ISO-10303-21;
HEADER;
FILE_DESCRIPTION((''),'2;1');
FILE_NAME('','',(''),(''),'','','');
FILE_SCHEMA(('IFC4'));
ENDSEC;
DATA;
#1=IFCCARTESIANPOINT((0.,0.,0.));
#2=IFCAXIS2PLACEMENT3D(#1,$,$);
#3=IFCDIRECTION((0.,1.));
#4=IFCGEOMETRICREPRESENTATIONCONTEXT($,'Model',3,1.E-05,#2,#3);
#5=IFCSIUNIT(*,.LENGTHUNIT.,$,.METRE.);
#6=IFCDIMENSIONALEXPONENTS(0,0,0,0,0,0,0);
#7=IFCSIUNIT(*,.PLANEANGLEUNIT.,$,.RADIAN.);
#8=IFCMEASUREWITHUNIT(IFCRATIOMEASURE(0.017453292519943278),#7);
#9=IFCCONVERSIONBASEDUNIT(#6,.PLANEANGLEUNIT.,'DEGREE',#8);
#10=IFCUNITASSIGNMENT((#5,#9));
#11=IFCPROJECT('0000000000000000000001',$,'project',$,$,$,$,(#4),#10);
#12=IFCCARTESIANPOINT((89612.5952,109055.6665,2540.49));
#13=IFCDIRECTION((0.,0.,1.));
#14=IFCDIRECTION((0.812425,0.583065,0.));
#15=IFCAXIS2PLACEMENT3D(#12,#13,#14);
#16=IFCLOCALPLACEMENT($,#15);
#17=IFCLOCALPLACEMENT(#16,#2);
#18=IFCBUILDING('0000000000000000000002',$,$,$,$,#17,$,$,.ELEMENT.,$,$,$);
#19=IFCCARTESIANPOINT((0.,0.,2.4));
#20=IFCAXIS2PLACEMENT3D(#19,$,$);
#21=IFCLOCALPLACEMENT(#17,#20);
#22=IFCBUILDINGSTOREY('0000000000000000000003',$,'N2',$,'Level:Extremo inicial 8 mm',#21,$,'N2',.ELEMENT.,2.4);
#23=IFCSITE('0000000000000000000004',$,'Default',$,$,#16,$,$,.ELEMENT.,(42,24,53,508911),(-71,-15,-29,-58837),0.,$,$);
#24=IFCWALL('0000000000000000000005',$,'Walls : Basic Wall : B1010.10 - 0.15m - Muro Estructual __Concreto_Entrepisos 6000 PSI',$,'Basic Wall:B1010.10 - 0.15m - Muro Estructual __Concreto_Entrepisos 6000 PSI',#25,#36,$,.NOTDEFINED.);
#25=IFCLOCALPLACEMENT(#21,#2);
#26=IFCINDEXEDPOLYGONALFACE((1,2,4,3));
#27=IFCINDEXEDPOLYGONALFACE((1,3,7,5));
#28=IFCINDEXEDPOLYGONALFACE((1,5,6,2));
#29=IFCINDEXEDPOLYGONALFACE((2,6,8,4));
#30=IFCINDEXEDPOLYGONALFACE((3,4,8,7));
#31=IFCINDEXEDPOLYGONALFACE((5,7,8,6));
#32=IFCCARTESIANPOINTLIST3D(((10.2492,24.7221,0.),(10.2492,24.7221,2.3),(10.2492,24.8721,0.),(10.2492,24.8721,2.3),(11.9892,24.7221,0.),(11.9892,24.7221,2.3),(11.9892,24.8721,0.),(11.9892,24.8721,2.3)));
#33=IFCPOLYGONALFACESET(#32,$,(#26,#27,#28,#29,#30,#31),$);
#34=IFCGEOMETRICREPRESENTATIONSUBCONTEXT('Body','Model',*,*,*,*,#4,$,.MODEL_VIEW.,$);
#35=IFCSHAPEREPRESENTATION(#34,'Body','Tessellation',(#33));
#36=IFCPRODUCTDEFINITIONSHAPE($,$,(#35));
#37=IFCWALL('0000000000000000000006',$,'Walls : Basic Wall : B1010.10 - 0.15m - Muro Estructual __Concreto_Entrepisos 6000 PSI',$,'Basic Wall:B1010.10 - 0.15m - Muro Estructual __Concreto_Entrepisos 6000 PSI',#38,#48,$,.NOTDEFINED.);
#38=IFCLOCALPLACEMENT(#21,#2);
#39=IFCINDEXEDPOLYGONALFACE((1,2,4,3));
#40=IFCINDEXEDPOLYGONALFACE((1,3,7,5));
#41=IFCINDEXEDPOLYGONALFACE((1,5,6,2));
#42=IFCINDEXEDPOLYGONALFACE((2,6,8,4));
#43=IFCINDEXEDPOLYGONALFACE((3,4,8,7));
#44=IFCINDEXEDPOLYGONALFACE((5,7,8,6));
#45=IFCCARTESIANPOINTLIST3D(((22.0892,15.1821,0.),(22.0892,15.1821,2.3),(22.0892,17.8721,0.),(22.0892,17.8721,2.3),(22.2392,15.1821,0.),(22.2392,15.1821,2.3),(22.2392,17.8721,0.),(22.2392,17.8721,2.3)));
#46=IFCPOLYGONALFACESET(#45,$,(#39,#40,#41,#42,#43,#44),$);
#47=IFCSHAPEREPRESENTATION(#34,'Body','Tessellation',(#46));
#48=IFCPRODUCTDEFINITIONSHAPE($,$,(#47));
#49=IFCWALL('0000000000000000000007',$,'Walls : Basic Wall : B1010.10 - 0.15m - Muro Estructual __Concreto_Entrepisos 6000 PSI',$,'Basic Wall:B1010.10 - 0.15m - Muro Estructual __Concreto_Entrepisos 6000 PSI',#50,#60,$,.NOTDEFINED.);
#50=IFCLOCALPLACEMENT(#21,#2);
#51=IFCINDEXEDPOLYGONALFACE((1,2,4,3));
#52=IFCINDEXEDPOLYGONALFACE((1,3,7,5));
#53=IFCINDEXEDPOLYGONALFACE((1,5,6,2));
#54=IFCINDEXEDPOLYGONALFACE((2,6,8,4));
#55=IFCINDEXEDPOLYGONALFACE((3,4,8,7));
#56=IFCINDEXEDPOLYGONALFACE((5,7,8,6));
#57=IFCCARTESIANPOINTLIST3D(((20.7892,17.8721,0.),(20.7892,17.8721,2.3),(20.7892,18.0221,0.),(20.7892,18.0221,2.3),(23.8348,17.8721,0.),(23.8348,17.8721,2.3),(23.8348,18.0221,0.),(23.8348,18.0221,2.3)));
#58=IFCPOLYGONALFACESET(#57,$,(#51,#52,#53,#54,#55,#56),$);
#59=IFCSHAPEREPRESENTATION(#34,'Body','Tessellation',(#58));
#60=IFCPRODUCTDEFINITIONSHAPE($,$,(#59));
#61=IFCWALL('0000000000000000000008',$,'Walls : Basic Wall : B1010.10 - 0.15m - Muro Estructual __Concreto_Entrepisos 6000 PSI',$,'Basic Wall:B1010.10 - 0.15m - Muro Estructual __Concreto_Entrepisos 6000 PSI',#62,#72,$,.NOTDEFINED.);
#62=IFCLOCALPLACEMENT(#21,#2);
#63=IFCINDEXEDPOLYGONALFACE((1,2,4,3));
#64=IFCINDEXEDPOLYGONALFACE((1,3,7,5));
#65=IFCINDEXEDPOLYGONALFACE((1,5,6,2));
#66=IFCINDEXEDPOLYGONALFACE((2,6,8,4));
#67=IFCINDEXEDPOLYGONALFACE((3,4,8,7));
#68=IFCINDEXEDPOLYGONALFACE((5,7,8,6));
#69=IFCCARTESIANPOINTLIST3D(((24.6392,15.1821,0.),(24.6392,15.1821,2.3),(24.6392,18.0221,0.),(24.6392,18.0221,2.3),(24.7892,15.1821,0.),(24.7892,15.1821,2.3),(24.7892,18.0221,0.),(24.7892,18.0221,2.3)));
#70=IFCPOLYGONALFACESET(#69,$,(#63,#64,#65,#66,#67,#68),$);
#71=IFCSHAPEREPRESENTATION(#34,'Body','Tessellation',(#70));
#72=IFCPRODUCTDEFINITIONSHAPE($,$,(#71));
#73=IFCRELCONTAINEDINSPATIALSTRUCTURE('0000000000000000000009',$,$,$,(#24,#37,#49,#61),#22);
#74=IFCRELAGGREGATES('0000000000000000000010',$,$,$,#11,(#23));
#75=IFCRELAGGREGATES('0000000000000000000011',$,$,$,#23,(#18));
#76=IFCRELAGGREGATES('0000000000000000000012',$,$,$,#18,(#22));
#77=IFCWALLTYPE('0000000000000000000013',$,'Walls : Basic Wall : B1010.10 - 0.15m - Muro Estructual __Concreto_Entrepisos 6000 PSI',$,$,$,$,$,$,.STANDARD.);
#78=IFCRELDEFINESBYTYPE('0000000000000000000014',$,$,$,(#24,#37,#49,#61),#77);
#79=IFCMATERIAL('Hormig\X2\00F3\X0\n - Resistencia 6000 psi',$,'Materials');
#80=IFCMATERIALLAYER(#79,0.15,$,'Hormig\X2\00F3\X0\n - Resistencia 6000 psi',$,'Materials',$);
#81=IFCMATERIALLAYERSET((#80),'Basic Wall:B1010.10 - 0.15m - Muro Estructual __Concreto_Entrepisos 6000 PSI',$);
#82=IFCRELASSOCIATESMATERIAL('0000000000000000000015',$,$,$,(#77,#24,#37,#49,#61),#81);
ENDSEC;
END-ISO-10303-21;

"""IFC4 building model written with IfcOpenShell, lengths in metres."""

from ifc_helpers import new_model, entity, si_unit, converted_unit, direction, frame, frame_2d, origin, place, context, subcontext, project, spatial, rectangle, extrude, material, layer, layer_set, layer_usage, type_object, element, save


model = new_model("IFC4")

# Units and contexts
model_context = context("Model", 3, precision=1e-05, world=origin(), true_north=direction((0.0, 1.0)))
body_context = subcontext(model_context, "Body", "Model", "MODEL_VIEW")
ifc_project = project(units=[si_unit("LENGTHUNIT", "METRE"), converted_unit("PLANEANGLEUNIT", "DEGREE", entity("IfcRatioMeasure", 0.017453292519943278), si_unit("PLANEANGLEUNIT", "RADIAN"), dimensions=[0, 0, 0, 0, 0, 0, 0])], contexts=[model_context])

# Site, building, storey
site_placement = place(None, frame((89612.5952, 109055.6665, 2540.49), z_axis=(0.0, 0.0, 1.0), x_axis=(0.812425, 0.583065, 0.0)))
site = spatial("IfcSite", under=ifc_project, at=site_placement, Name="Default", CompositionType="ELEMENT", RefLatitude=(42, 24, 53, 508911), RefLongitude=(-71, -15, -29, -58837), RefElevation=0.0)
building_placement = place(site_placement, origin())
building = spatial("IfcBuilding", under=site, at=building_placement, CompositionType="ELEMENT")
storey_placement = place(building_placement, frame((0.0, 0.0, 2.4)))
storey = spatial("IfcBuildingStorey", under=building, at=storey_placement, Name="N2", ObjectType="Level:Extremo inicial 8 mm", LongName="N2", CompositionType="ELEMENT", Elevation=2.4)

# Walls
ifc_material = material(Name="Hormigón - Resistencia 6000 psi", Category="Materials")
ifc_layer_1 = layer(ifc_material, 0.15, Name="Hormigón - Resistencia 6000 psi", Category="Materials")
ifc_layer_set_1 = layer_set([ifc_layer_1], Name="Basic Wall:B1010.10 - 0.15m - Muro Estructual __Concreto_Entrepisos 6000 PSI")
wall_type_1 = type_object("IfcWallType", Name="Walls : Basic Wall : B1010.10 - 0.15m - Muro Estructual __Concreto_Entrepisos 6000 PSI", PredefinedType="STANDARD", material=ifc_layer_set_1)
ifc_layer_usage_1 = layer_usage(ifc_layer_set_1, "AXIS2", "POSITIVE", -0.075)
wall_1_placement = place(storey_placement, frame((11.9892, 24.7971, 0.0), z_axis=(0.0, 0.0, 1.0), x_axis=(-1.0, 0.0, 0.0)))
element("IfcWall", 1, at=wall_1_placement, inside=storey, type_object=wall_type_1, material=ifc_layer_usage_1, Name="Walls : Basic Wall : B1010.10 - 0.15m - Muro Estructual __Concreto_Entrepisos 6000 PSI", ObjectType="Basic Wall:B1010.10 - 0.15m - Muro Estructual __Concreto_Entrepisos 6000 PSI", PredefinedType="NOTDEFINED", context=body_context, shape_type="SweptSolid", body=[
    extrude(rectangle(XDim=1.74, YDim=0.15, at=frame_2d((0.87, 0.0), x_axis=(-1.0, 0.0))), origin(), (0.0, 0.0, 1.0), 2.3),
])
ifc_layer_usage_2 = layer_usage(ifc_layer_set_1, "AXIS2", "POSITIVE", -0.075)
wall_2_placement = place(storey_placement, frame((22.1642, 15.1821, 0.0), z_axis=(0.0, 0.0, 1.0), x_axis=(0.0, 1.0, 0.0)))
element("IfcWall", 2, at=wall_2_placement, inside=storey, type_object=wall_type_1, material=ifc_layer_usage_2, Name="Walls : Basic Wall : B1010.10 - 0.15m - Muro Estructual __Concreto_Entrepisos 6000 PSI", ObjectType="Basic Wall:B1010.10 - 0.15m - Muro Estructual __Concreto_Entrepisos 6000 PSI", PredefinedType="NOTDEFINED", context=body_context, shape_type="SweptSolid", body=[
    extrude(rectangle(XDim=2.69, YDim=0.15, at=frame_2d((1.345, 0.0), x_axis=(-1.0, 0.0))), origin(), (0.0, 0.0, 1.0), 2.3),
])
ifc_layer_usage_3 = layer_usage(ifc_layer_set_1, "AXIS2", "POSITIVE", -0.075)
wall_3_placement = place(storey_placement, frame((20.7892, 17.9471, 0.0)))
element("IfcWall", 3, at=wall_3_placement, inside=storey, type_object=wall_type_1, material=ifc_layer_usage_3, Name="Walls : Basic Wall : B1010.10 - 0.15m - Muro Estructual __Concreto_Entrepisos 6000 PSI", ObjectType="Basic Wall:B1010.10 - 0.15m - Muro Estructual __Concreto_Entrepisos 6000 PSI", PredefinedType="NOTDEFINED", context=body_context, shape_type="SweptSolid", body=[
    extrude(rectangle(XDim=3.0455, YDim=0.15, at=frame_2d((1.5228, 0.0), x_axis=(-1.0, 0.0))), origin(), (0.0, 0.0, 1.0), 2.3),
])
ifc_layer_usage_4 = layer_usage(ifc_layer_set_1, "AXIS2", "POSITIVE", -0.075)
wall_4_placement = place(storey_placement, frame((24.7142, 15.1821, 0.0), z_axis=(0.0, 0.0, 1.0), x_axis=(0.0, 1.0, 0.0)))
element("IfcWall", 4, at=wall_4_placement, inside=storey, type_object=wall_type_1, material=ifc_layer_usage_4, Name="Walls : Basic Wall : B1010.10 - 0.15m - Muro Estructual __Concreto_Entrepisos 6000 PSI", ObjectType="Basic Wall:B1010.10 - 0.15m - Muro Estructual __Concreto_Entrepisos 6000 PSI", PredefinedType="NOTDEFINED", context=body_context, shape_type="SweptSolid", body=[
    extrude(rectangle(XDim=2.84, YDim=0.15, at=frame_2d((1.42, 0.0), x_axis=(-1.0, 0.0))), origin(), (0.0, 0.0, 1.0), 2.3),
])

save(model, "model.ifc")
